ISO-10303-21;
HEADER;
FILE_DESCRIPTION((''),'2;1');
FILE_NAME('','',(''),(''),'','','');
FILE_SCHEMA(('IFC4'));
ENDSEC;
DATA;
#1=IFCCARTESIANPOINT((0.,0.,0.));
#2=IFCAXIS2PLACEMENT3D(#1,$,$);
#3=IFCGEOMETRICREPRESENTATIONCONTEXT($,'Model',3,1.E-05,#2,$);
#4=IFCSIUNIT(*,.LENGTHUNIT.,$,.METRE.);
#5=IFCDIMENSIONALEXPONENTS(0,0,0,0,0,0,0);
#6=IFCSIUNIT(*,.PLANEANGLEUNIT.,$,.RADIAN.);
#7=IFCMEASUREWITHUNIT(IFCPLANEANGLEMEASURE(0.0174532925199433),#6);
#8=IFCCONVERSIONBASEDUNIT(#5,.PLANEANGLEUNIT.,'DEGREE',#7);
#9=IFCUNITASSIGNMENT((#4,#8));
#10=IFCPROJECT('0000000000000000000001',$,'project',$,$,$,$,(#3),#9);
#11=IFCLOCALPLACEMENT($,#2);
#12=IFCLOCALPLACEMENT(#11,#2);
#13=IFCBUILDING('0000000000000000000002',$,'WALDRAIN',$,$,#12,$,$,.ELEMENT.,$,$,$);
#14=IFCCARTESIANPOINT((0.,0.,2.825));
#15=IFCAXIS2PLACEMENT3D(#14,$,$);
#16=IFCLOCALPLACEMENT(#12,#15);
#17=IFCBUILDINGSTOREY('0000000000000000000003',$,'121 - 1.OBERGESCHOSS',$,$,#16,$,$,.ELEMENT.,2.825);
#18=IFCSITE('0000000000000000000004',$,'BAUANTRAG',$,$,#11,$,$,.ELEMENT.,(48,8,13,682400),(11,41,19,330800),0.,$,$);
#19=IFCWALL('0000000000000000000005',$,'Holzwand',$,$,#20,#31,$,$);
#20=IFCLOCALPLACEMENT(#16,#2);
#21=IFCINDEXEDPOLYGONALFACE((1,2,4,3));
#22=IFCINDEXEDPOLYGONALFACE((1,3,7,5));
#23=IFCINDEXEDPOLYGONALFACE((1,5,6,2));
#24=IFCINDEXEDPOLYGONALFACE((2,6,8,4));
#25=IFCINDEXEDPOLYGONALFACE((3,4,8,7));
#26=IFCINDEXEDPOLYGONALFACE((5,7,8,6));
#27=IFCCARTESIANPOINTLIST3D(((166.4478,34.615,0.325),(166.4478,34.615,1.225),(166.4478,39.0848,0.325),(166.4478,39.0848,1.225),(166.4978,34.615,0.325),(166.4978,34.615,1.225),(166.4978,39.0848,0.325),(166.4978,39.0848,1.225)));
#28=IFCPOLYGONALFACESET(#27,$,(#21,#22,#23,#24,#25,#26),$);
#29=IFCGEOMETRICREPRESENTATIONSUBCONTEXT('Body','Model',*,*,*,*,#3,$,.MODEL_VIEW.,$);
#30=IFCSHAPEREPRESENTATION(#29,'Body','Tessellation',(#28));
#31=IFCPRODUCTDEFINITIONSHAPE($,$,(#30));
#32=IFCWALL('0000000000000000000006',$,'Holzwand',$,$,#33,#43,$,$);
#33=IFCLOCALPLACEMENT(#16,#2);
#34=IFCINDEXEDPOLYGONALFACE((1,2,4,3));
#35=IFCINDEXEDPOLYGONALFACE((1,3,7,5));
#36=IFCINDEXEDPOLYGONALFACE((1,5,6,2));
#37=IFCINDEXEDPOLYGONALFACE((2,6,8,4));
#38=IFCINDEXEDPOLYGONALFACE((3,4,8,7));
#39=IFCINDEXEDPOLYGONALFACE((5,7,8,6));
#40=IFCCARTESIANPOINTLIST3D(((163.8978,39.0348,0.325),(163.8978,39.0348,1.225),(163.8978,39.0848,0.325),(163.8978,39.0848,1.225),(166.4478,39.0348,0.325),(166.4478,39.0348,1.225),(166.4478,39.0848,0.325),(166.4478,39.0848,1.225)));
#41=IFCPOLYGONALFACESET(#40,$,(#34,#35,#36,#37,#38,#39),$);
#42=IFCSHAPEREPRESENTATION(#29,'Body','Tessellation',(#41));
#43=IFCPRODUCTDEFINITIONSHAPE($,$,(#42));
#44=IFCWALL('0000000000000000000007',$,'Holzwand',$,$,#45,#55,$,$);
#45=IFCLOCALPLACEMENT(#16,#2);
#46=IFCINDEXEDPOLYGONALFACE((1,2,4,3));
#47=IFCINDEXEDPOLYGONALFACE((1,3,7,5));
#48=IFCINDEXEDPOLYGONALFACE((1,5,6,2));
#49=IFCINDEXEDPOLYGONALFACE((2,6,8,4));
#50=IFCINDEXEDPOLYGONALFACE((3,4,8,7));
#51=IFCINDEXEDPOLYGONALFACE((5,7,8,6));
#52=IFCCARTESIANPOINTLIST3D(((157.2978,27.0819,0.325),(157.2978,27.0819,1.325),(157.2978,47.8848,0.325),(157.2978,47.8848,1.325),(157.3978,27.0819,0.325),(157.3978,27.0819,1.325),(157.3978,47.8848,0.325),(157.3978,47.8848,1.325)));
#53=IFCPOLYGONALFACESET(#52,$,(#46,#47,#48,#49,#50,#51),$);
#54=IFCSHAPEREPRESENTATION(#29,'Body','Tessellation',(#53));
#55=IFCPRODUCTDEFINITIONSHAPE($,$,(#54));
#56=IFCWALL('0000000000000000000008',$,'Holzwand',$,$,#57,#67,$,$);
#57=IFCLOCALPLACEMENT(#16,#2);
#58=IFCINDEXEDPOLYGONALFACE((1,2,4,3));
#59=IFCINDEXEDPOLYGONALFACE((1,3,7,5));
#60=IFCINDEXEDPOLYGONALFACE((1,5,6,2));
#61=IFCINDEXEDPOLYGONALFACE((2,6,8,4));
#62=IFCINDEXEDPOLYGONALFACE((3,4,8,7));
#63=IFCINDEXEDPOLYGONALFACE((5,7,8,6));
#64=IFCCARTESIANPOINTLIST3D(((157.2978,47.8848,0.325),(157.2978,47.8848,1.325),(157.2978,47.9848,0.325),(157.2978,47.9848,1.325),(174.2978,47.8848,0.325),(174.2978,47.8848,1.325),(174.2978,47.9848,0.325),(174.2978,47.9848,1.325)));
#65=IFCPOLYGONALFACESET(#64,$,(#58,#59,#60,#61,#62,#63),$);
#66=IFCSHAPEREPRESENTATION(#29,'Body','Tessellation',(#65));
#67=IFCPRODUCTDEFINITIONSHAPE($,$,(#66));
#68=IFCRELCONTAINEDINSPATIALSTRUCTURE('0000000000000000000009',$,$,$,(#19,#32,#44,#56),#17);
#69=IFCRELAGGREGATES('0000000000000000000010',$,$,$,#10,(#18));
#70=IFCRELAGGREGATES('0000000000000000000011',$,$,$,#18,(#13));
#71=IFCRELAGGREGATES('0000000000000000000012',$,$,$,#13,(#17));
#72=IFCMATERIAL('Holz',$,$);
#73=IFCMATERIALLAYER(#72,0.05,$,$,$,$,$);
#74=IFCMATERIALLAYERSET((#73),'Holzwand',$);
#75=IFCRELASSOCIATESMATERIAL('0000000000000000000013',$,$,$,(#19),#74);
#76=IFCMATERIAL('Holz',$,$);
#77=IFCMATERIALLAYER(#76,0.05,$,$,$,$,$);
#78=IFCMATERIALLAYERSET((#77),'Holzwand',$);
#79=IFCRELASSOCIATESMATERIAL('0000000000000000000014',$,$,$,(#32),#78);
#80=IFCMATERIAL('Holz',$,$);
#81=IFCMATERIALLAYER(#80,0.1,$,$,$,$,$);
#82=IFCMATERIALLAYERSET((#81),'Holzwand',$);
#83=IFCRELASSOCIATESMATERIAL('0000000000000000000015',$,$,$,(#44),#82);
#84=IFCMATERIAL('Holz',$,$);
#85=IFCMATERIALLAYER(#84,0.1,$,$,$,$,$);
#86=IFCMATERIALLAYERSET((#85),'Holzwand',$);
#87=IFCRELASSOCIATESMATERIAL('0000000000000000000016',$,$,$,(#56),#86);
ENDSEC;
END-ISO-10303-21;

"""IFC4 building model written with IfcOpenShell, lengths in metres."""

from ifc_helpers import new_model, entity, si_unit, converted_unit, frame, frame_2d, origin, origin_with_axes, place, context, subcontext, project, spatial, rectangle, extrude, material, layer, layer_set, layer_usage, element, save


model = new_model("IFC4")

# Units and contexts
model_context = context("Model", 3, precision=1e-05, world=origin())
body_context = subcontext(model_context, "Body", "Model", "MODEL_VIEW")
ifc_project = project(units=[si_unit("LENGTHUNIT", "METRE"), converted_unit("PLANEANGLEUNIT", "DEGREE", entity("IfcPlaneAngleMeasure", 0.0174532925199433), si_unit("PLANEANGLEUNIT", "RADIAN"), dimensions=[0, 0, 0, 0, 0, 0, 0])], contexts=[model_context])

# Site, building, storey
site_placement = place(None, origin())
site = spatial("IfcSite", under=ifc_project, at=site_placement, Name="BAUANTRAG", CompositionType="ELEMENT", RefLatitude=(48, 8, 13, 682400), RefLongitude=(11, 41, 19, 330800), RefElevation=0.0)
building_placement = place(site_placement, origin())
building = spatial("IfcBuilding", under=site, at=building_placement, Name="WALDRAIN", CompositionType="ELEMENT")
storey_placement = place(building_placement, frame((0.0, 0.0, 2.825)))
storey = spatial("IfcBuildingStorey", under=building, at=storey_placement, Name="121 - 1.OBERGESCHOSS", CompositionType="ELEMENT", Elevation=2.825)

# Walls
ifc_material_1 = material(Name="Holz")
ifc_layer_1 = layer(ifc_material_1, 0.05)
ifc_layer_set_1 = layer_set([ifc_layer_1], Name="Holzwand")
ifc_layer_usage_1 = layer_usage(ifc_layer_set_1, "AXIS2", "POSITIVE", 0.0)
wall_1_placement = place(storey_placement, frame((166.4478, 39.0848, 0.325), z_axis=(0.0, 0.0, 1.0), x_axis=(0.0, -1.0, 0.0)))
element("IfcWall", 1, at=wall_1_placement, inside=storey, material=ifc_layer_usage_1, Name="Holzwand", context=body_context, shape_type="SweptSolid", body=[
    extrude(rectangle(XDim=4.4698, YDim=0.05, at=frame_2d((2.2349, 0.025), x_axis=(1.0, 0.0))), origin_with_axes(), (0.0, 0.0, 1.0), 0.9),
])
ifc_material_2 = material(Name="Holz")
ifc_layer_2 = layer(ifc_material_2, 0.05)
ifc_layer_set_2 = layer_set([ifc_layer_2], Name="Holzwand")
ifc_layer_usage_2 = layer_usage(ifc_layer_set_2, "AXIS2", "POSITIVE", 0.0)
wall_2_placement = place(storey_placement, frame((163.8978, 39.0348, 0.325)))
element("IfcWall", 2, at=wall_2_placement, inside=storey, material=ifc_layer_usage_2, Name="Holzwand", context=body_context, shape_type="SweptSolid", body=[
    extrude(rectangle(XDim=2.55, YDim=0.05, at=frame_2d((1.275, 0.025), x_axis=(1.0, 0.0))), origin_with_axes(), (0.0, 0.0, 1.0), 0.9),
])
ifc_material_3 = material(Name="Holz")
ifc_layer_3 = layer(ifc_material_3, 0.1)
ifc_layer_set_3 = layer_set([ifc_layer_3], Name="Holzwand")
ifc_layer_usage_3 = layer_usage(ifc_layer_set_3, "AXIS2", "POSITIVE", 0.0)
wall_3_placement = place(storey_placement, frame((157.2978, 47.8848, 0.325), z_axis=(0.0, 0.0, 1.0), x_axis=(0.0, -1.0, 0.0)))
element("IfcWall", 3, at=wall_3_placement, inside=storey, material=ifc_layer_usage_3, Name="Holzwand", context=body_context, shape_type="SweptSolid", body=[
    extrude(rectangle(XDim=20.8029, YDim=0.1, at=frame_2d((10.4014, 0.05), x_axis=(1.0, 0.0))), origin_with_axes(), (0.0, 0.0, 1.0), 1.0),
])
ifc_material_4 = material(Name="Holz")
ifc_layer_4 = layer(ifc_material_4, 0.1)
ifc_layer_set_4 = layer_set([ifc_layer_4], Name="Holzwand")
ifc_layer_usage_4 = layer_usage(ifc_layer_set_4, "AXIS2", "POSITIVE", 0.0)
wall_4_placement = place(storey_placement, frame((174.2978, 47.9848, 0.325), z_axis=(0.0, 0.0, 1.0), x_axis=(-1.0, 0.0, 0.0)))
element("IfcWall", 4, at=wall_4_placement, inside=storey, material=ifc_layer_usage_4, Name="Holzwand", context=body_context, shape_type="SweptSolid", body=[
    extrude(rectangle(XDim=17.0, YDim=0.1, at=frame_2d((8.5, 0.05), x_axis=(1.0, 0.0))), origin_with_axes(), (0.0, 0.0, 1.0), 1.0),
])

save(model, "model.ifc")
